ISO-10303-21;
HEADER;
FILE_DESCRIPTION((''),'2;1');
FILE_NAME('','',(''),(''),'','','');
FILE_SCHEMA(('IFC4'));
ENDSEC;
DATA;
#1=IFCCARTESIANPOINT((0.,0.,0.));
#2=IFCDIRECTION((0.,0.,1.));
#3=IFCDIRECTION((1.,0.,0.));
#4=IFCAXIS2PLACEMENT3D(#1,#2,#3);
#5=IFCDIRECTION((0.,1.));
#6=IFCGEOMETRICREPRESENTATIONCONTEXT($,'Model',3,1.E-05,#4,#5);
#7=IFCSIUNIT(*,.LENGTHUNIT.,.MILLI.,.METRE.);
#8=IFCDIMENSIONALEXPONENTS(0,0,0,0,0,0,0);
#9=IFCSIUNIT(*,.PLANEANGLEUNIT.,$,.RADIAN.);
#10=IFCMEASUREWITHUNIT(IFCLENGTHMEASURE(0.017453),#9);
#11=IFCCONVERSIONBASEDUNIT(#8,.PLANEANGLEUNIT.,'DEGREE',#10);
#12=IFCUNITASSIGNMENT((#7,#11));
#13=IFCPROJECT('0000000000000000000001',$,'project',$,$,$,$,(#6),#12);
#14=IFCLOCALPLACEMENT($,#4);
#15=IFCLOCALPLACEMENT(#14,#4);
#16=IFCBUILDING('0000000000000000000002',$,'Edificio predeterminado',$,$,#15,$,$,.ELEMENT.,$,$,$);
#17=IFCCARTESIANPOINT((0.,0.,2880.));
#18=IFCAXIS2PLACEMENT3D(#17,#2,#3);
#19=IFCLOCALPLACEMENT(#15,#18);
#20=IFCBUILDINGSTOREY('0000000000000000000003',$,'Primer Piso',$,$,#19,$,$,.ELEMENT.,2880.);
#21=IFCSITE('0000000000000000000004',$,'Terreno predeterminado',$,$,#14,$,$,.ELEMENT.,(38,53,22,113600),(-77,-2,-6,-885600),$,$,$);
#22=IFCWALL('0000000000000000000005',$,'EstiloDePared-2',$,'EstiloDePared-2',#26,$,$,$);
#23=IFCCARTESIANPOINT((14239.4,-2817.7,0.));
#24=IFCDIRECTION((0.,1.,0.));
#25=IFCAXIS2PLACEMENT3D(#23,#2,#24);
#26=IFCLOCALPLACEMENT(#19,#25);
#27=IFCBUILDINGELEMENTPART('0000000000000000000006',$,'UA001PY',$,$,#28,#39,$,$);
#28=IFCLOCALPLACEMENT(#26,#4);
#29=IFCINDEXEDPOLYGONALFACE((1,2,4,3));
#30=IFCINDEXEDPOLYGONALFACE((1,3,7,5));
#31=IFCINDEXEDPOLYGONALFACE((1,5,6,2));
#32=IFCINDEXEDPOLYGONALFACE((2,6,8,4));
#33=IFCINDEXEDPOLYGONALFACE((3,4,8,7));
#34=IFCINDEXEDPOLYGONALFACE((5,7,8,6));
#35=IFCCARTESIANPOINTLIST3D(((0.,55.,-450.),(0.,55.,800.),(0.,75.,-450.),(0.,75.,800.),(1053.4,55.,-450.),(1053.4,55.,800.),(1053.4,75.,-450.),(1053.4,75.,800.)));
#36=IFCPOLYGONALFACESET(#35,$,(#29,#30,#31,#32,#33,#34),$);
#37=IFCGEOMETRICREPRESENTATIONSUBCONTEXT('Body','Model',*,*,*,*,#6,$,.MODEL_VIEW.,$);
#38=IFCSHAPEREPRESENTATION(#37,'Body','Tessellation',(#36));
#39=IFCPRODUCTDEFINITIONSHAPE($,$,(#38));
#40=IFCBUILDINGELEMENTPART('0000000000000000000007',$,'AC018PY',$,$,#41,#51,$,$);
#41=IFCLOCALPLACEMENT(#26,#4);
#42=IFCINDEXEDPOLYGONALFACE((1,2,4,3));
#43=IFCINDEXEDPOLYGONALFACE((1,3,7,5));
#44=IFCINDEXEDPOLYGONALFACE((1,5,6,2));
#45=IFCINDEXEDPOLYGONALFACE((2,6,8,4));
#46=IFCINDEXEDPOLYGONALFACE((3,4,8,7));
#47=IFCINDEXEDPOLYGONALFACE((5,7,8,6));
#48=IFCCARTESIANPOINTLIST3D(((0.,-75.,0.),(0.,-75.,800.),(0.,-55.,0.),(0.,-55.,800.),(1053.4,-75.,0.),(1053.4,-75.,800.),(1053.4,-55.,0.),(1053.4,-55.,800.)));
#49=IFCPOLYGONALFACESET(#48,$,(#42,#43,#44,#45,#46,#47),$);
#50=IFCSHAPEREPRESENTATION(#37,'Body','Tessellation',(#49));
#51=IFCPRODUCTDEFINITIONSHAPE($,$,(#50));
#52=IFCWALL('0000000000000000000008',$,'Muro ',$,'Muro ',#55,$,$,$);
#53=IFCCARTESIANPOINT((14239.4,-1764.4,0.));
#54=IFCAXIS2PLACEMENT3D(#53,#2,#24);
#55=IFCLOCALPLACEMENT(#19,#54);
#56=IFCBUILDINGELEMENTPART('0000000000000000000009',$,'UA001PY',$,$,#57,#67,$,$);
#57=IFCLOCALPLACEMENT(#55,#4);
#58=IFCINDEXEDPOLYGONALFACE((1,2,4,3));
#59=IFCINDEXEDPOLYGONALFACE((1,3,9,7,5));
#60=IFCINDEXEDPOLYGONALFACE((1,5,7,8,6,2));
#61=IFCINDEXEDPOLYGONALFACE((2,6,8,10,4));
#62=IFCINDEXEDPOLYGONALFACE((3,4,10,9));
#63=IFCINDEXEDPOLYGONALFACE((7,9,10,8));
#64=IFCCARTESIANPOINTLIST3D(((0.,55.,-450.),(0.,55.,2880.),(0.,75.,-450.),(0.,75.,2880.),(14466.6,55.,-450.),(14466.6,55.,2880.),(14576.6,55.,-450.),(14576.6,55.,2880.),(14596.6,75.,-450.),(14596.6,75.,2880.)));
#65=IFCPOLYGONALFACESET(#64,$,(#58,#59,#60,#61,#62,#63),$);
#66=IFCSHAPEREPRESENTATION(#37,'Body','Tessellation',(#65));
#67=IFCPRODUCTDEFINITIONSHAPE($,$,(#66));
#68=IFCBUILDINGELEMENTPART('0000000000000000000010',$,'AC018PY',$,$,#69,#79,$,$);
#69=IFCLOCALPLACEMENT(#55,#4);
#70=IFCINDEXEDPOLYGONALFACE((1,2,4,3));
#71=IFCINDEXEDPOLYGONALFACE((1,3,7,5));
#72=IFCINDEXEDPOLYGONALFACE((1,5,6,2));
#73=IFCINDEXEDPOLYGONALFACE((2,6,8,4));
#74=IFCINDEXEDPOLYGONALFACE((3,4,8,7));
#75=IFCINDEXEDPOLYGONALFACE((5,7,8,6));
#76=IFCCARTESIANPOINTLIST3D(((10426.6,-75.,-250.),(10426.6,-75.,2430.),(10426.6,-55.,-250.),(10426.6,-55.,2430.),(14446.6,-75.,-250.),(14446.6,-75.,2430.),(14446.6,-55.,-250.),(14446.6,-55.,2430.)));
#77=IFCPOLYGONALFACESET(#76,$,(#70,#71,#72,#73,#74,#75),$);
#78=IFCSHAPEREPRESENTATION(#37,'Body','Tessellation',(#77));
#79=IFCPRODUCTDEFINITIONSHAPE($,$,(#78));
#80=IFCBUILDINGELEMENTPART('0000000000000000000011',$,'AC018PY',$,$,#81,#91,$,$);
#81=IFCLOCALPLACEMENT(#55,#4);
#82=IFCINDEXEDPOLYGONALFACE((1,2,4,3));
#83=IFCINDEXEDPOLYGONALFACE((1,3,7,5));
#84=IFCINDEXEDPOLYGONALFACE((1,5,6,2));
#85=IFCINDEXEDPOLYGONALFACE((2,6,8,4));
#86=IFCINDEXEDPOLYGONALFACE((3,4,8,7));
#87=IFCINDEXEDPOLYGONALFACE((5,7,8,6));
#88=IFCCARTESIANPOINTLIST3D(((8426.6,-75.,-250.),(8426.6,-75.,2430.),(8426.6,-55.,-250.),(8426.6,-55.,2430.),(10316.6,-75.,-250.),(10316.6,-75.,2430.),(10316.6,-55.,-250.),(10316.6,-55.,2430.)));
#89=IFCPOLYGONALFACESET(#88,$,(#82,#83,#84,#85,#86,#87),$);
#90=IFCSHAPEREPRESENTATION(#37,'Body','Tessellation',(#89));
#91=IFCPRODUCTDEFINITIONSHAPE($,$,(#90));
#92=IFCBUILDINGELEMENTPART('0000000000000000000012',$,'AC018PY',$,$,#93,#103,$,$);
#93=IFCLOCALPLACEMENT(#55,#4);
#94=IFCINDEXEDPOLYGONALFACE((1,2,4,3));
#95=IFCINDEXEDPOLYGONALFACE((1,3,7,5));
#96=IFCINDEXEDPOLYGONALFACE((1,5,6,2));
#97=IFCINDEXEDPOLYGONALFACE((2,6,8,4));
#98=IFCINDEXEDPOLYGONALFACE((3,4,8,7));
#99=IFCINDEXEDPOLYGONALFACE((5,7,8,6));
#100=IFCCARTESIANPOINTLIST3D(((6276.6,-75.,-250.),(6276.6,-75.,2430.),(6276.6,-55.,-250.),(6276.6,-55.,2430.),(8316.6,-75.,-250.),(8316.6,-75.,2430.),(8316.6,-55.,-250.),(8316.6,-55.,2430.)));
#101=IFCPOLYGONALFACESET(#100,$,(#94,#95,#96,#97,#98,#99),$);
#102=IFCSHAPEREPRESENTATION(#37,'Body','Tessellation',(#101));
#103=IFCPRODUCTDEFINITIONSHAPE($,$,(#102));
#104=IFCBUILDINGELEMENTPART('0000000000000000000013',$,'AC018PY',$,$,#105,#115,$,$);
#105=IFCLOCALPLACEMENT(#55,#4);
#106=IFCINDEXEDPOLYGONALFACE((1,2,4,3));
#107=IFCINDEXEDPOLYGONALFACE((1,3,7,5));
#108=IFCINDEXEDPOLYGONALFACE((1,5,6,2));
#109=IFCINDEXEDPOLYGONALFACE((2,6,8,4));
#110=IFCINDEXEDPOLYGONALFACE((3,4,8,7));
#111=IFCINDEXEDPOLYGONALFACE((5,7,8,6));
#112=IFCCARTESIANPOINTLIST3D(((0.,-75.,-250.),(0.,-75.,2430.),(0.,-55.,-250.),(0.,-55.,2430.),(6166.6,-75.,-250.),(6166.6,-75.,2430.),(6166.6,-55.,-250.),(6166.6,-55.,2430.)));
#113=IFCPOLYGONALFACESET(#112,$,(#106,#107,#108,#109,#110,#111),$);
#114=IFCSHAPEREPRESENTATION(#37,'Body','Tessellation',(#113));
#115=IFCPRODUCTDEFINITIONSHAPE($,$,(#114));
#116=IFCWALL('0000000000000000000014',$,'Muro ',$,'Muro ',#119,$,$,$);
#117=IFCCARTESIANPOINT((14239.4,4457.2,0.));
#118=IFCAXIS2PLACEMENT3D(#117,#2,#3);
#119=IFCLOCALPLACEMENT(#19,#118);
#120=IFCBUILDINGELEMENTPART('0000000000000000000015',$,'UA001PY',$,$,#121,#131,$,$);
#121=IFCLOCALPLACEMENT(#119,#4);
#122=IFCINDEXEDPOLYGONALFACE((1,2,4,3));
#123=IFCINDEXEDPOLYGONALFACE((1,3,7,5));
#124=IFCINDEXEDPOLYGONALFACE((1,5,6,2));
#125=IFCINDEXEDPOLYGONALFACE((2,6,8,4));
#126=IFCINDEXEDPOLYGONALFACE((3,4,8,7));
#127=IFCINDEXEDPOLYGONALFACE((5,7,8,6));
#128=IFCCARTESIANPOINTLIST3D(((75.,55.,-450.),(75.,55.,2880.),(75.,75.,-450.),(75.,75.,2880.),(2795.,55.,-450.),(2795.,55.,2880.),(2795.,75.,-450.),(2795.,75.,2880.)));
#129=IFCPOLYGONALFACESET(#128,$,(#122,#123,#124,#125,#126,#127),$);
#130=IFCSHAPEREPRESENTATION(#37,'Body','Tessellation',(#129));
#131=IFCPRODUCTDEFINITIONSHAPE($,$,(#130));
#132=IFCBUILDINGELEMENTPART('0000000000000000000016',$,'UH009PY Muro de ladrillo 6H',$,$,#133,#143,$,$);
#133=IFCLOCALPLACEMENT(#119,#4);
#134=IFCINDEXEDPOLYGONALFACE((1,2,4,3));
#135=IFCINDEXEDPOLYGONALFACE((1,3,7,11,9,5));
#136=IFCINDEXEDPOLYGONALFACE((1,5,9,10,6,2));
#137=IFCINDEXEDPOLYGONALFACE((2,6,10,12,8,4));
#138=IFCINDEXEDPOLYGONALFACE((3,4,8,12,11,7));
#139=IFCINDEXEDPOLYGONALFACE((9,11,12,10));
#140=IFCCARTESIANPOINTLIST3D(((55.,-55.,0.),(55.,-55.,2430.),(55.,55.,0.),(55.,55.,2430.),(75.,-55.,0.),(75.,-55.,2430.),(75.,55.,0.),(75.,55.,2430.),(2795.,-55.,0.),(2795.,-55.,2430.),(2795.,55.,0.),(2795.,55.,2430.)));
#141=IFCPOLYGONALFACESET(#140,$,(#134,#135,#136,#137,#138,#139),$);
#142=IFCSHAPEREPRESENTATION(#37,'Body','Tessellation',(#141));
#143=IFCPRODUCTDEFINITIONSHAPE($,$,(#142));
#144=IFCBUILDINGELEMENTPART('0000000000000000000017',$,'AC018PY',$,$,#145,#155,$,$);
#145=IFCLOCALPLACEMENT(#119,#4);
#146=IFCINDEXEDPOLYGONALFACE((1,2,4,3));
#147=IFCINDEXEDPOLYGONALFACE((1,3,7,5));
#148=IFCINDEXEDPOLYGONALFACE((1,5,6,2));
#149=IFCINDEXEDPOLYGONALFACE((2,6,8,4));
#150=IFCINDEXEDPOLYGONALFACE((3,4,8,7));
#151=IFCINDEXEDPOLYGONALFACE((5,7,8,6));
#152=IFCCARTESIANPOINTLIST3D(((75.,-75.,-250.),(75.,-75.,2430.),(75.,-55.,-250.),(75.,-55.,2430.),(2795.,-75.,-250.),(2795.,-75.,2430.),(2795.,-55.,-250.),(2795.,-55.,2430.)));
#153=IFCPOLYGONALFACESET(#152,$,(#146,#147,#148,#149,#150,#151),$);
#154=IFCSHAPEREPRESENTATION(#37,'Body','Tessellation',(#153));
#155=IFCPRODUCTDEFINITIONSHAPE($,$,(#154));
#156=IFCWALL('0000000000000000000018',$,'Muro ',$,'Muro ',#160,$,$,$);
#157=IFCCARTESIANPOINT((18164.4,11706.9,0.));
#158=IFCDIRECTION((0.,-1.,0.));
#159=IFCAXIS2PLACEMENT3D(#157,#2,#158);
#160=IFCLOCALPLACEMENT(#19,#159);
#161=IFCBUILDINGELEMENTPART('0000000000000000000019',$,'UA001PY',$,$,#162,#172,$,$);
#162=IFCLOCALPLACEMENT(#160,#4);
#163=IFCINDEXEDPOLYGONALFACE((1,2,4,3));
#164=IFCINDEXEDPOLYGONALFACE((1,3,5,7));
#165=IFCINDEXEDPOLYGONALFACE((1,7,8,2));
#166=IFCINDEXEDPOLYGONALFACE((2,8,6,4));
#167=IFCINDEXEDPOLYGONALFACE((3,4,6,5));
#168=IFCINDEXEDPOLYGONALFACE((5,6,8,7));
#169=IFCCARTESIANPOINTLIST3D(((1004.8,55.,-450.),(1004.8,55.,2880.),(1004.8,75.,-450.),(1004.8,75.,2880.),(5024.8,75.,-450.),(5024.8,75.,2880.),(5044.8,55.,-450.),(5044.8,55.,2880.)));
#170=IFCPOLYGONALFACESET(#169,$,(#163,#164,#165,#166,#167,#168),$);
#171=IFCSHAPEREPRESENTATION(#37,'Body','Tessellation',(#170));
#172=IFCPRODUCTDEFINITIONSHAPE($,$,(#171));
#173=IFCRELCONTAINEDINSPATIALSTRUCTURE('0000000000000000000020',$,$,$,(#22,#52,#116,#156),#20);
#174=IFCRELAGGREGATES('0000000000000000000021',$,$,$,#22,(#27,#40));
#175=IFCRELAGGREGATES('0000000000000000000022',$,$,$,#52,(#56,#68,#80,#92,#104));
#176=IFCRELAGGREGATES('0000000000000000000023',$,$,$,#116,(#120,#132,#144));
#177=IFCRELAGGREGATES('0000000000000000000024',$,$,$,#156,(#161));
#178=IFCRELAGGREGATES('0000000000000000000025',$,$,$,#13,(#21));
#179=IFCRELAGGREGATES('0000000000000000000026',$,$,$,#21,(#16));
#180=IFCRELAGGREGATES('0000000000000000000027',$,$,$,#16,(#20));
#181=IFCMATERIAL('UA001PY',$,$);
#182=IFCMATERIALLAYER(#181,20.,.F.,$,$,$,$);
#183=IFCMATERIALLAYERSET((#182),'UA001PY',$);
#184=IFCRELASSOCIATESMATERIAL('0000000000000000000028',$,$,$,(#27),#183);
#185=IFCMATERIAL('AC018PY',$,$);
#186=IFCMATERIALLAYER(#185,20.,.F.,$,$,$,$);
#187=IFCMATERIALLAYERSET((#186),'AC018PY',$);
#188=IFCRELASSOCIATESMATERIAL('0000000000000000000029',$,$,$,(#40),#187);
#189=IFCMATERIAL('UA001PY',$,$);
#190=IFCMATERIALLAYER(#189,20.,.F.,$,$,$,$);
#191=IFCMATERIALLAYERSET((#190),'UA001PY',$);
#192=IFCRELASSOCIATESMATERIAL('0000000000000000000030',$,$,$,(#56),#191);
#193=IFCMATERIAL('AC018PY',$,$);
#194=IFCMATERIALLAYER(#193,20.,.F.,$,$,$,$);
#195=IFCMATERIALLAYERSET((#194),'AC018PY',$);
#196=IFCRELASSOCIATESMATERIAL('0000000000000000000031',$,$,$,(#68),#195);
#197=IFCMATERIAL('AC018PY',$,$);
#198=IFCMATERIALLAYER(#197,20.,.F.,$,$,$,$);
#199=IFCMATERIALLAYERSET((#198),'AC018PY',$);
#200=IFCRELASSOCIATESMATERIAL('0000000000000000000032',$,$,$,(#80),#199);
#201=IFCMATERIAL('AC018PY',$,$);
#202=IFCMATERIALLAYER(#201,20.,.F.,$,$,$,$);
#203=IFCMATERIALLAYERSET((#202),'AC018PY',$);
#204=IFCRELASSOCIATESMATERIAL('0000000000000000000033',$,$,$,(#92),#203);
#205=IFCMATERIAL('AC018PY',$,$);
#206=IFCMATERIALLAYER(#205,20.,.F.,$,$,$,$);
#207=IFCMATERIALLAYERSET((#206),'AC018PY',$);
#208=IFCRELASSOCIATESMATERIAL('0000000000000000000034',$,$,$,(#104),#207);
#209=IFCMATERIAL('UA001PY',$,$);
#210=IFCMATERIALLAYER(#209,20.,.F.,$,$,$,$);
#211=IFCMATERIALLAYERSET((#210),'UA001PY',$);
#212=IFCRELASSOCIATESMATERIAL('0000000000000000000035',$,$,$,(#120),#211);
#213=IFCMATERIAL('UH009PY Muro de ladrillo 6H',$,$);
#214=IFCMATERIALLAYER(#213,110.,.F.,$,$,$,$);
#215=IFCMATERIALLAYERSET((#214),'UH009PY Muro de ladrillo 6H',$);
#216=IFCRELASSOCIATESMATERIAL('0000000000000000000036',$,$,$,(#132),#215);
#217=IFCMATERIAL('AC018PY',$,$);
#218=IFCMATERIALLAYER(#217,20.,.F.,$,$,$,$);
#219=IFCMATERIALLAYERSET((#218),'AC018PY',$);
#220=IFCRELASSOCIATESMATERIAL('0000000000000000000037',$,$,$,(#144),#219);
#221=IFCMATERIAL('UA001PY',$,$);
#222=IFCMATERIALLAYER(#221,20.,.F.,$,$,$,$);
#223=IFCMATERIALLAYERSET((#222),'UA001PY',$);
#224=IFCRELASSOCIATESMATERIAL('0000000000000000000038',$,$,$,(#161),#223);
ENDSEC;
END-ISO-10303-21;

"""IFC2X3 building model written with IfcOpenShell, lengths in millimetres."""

from ifc_helpers import new_model, entity, si_unit, converted_unit, direction, frame, origin_with_axes, place, context, subcontext, project, spatial, polyline, outline, extrude, material, layer, layer_set, layer_usage, element, aggregate, save


model = new_model("IFC2X3")

# Units and contexts
model_context = context("Model", 3, precision=1e-05, world=origin_with_axes(), true_north=direction((0.0, 1.0)))
body_context = subcontext(model_context, "Body", "Model", "MODEL_VIEW")
ifc_project = project(units=[si_unit("LENGTHUNIT", "METRE", prefix="MILLI"), converted_unit("PLANEANGLEUNIT", "DEGREE", entity("IfcLengthMeasure", 0.017453), si_unit("PLANEANGLEUNIT", "RADIAN"), dimensions=[0, 0, 0, 0, 0, 0, 0])], contexts=[model_context])

# Site, building, storey
site_placement = place(None, origin_with_axes())
site = spatial("IfcSite", under=ifc_project, at=site_placement, Name="Terreno predeterminado", CompositionType="ELEMENT", RefLatitude=(38, 53, 22, 113600), RefLongitude=(-77, -2, -6, -885600))
building_placement = place(site_placement, origin_with_axes())
building = spatial("IfcBuilding", under=site, at=building_placement, Name="Edificio predeterminado", CompositionType="ELEMENT")
storey_placement = place(building_placement, frame((0.0, 0.0, 2880.0), z_axis=(0.0, 0.0, 1.0), x_axis=(1.0, 0.0, 0.0)))
storey = spatial("IfcBuildingStorey", under=building, at=storey_placement, Name="Primer Piso", CompositionType="ELEMENT", Elevation=2880.0)

# Walls, building element parts
wall_1_placement = place(storey_placement, frame((14239.4, -2817.7, 0.0), z_axis=(0.0, 0.0, 1.0), x_axis=(0.0, 1.0, 0.0)))
wall_1 = element("IfcWall", 1, at=wall_1_placement, inside=storey, Name="EstiloDePared-2", ObjectType="EstiloDePared-2")
ifc_material_1 = material(Name="UA001PY")
ifc_layer_1 = layer(ifc_material_1, 20.0, ventilated=False)
ifc_layer_set_1 = layer_set([ifc_layer_1], Name="UA001PY")
ifc_layer_usage_1 = layer_usage(ifc_layer_set_1, "AXIS2", "NEGATIVE", -75.0)
building_element_part_1_placement = place(wall_1_placement, origin_with_axes())
building_element_part_1 = element("IfcBuildingElementPart", 2, at=building_element_part_1_placement, material=ifc_layer_usage_1, Name="UA001PY", context=body_context, shape_type="SweptSolid", body=[
    extrude(outline(polyline([(1053.4, 75.0), (1053.4, 55.0), (0.0, 55.0), (0.0, 75.0), (1053.4, 75.0)])), frame((0.0, 0.0, -450.0), z_axis=(0.0, 0.0, 1.0), x_axis=(1.0, 0.0, 0.0)), (0.0, 0.0, 1.0), 1250.0),
])
ifc_material_2 = material(Name="AC018PY")
ifc_layer_2 = layer(ifc_material_2, 20.0, ventilated=False)
ifc_layer_set_2 = layer_set([ifc_layer_2], Name="AC018PY")
ifc_layer_usage_2 = layer_usage(ifc_layer_set_2, "AXIS2", "NEGATIVE", 55.0)
building_element_part_2_placement = place(wall_1_placement, origin_with_axes())
building_element_part_2 = element("IfcBuildingElementPart", 3, at=building_element_part_2_placement, material=ifc_layer_usage_2, Name="AC018PY", context=body_context, shape_type="SweptSolid", body=[
    extrude(outline(polyline([(1053.4, -55.0), (1053.4, -75.0), (0.0, -75.0), (0.0, -55.0), (1053.4, -55.0)])), origin_with_axes(), (0.0, 0.0, 1.0), 800.0),
])
aggregate(wall_1, [building_element_part_1, building_element_part_2])
wall_2_placement = place(storey_placement, frame((14239.4, -1764.4, 0.0), z_axis=(0.0, 0.0, 1.0), x_axis=(0.0, 1.0, 0.0)))
wall_2 = element("IfcWall", 4, at=wall_2_placement, inside=storey, Name="Muro ", ObjectType="Muro ")
ifc_material_3 = material(Name="UA001PY")
ifc_layer_3 = layer(ifc_material_3, 20.0, ventilated=False)
ifc_layer_set_3 = layer_set([ifc_layer_3], Name="UA001PY")
ifc_layer_usage_3 = layer_usage(ifc_layer_set_3, "AXIS2", "NEGATIVE", -75.0)
building_element_part_3_placement = place(wall_2_placement, origin_with_axes())
building_element_part_3 = element("IfcBuildingElementPart", 5, at=building_element_part_3_placement, material=ifc_layer_usage_3, Name="UA001PY", context=body_context, shape_type="SweptSolid", body=[
    extrude(outline(polyline([(14596.6, 75.0), (14576.6, 55.0), (14466.6, 55.0), (0.0, 55.0), (0.0, 75.0), (14596.6, 75.0)])), frame((0.0, 0.0, -450.0), z_axis=(0.0, 0.0, 1.0), x_axis=(1.0, 0.0, 0.0)), (0.0, 0.0, 1.0), 3330.0),
])
ifc_material_4 = material(Name="AC018PY")
ifc_layer_4 = layer(ifc_material_4, 20.0, ventilated=False)
ifc_layer_set_4 = layer_set([ifc_layer_4], Name="AC018PY")
ifc_layer_usage_4 = layer_usage(ifc_layer_set_4, "AXIS2", "NEGATIVE", 55.0)
building_element_part_4_placement = place(wall_2_placement, origin_with_axes())
building_element_part_4 = element("IfcBuildingElementPart", 6, at=building_element_part_4_placement, material=ifc_layer_usage_4, Name="AC018PY", context=body_context, shape_type="SweptSolid", body=[
    extrude(outline(polyline([(14446.6, -55.0), (14446.6, -75.0), (10426.6, -75.0), (10426.6, -55.0), (14446.6, -55.0)])), frame((0.0, 0.0, -250.0), z_axis=(0.0, 0.0, 1.0), x_axis=(1.0, 0.0, 0.0)), (0.0, 0.0, 1.0), 2680.0),
])
ifc_material_5 = material(Name="AC018PY")
ifc_layer_5 = layer(ifc_material_5, 20.0, ventilated=False)
ifc_layer_set_5 = layer_set([ifc_layer_5], Name="AC018PY")
ifc_layer_usage_5 = layer_usage(ifc_layer_set_5, "AXIS2", "NEGATIVE", 55.0)
building_element_part_5_placement = place(wall_2_placement, origin_with_axes())
building_element_part_5 = element("IfcBuildingElementPart", 7, at=building_element_part_5_placement, material=ifc_layer_usage_5, Name="AC018PY", context=body_context, shape_type="SweptSolid", body=[
    extrude(outline(polyline([(10316.6, -55.0), (10316.6, -75.0), (8426.6, -75.0), (8426.6, -55.0), (10316.6, -55.0)])), frame((0.0, 0.0, -250.0), z_axis=(0.0, 0.0, 1.0), x_axis=(1.0, 0.0, 0.0)), (0.0, 0.0, 1.0), 2680.0),
])
ifc_material_6 = material(Name="AC018PY")
ifc_layer_6 = layer(ifc_material_6, 20.0, ventilated=False)
ifc_layer_set_6 = layer_set([ifc_layer_6], Name="AC018PY")
ifc_layer_usage_6 = layer_usage(ifc_layer_set_6, "AXIS2", "NEGATIVE", 55.0)
building_element_part_6_placement = place(wall_2_placement, origin_with_axes())
building_element_part_6 = element("IfcBuildingElementPart", 8, at=building_element_part_6_placement, material=ifc_layer_usage_6, Name="AC018PY", context=body_context, shape_type="SweptSolid", body=[
    extrude(outline(polyline([(8316.6, -55.0), (8316.6, -75.0), (6276.6, -75.0), (6276.6, -55.0), (8316.6, -55.0)])), frame((0.0, 0.0, -250.0), z_axis=(0.0, 0.0, 1.0), x_axis=(1.0, 0.0, 0.0)), (0.0, 0.0, 1.0), 2680.0),
])
ifc_material_7 = material(Name="AC018PY")
ifc_layer_7 = layer(ifc_material_7, 20.0, ventilated=False)
ifc_layer_set_7 = layer_set([ifc_layer_7], Name="AC018PY")
ifc_layer_usage_7 = layer_usage(ifc_layer_set_7, "AXIS2", "NEGATIVE", 55.0)
building_element_part_7_placement = place(wall_2_placement, origin_with_axes())
building_element_part_7 = element("IfcBuildingElementPart", 9, at=building_element_part_7_placement, material=ifc_layer_usage_7, Name="AC018PY", context=body_context, shape_type="SweptSolid", body=[
    extrude(outline(polyline([(6166.6, -55.0), (6166.6, -75.0), (0.0, -75.0), (0.0, -55.0), (6166.6, -55.0)])), frame((0.0, 0.0, -250.0), z_axis=(0.0, 0.0, 1.0), x_axis=(1.0, 0.0, 0.0)), (0.0, 0.0, 1.0), 2680.0),
])
aggregate(wall_2, [building_element_part_3, building_element_part_4, building_element_part_5, building_element_part_6, building_element_part_7])
wall_3_placement = place(storey_placement, frame((14239.4, 4457.2, 0.0), z_axis=(0.0, 0.0, 1.0), x_axis=(1.0, 0.0, 0.0)))
wall_3 = element("IfcWall", 10, at=wall_3_placement, inside=storey, Name="Muro ", ObjectType="Muro ")
ifc_material_8 = material(Name="UA001PY")
ifc_layer_8 = layer(ifc_material_8, 20.0, ventilated=False)
ifc_layer_set_8 = layer_set([ifc_layer_8], Name="UA001PY")
ifc_layer_usage_8 = layer_usage(ifc_layer_set_8, "AXIS2", "NEGATIVE", -75.0)
building_element_part_8_placement = place(wall_3_placement, origin_with_axes())
building_element_part_8 = element("IfcBuildingElementPart", 11, at=building_element_part_8_placement, material=ifc_layer_usage_8, Name="UA001PY", context=body_context, shape_type="SweptSolid", body=[
    extrude(outline(polyline([(2795.0, 75.0), (2795.0, 55.0), (75.0, 55.0), (75.0, 75.0), (2795.0, 75.0)])), frame((0.0, 0.0, -450.0), z_axis=(0.0, 0.0, 1.0), x_axis=(1.0, 0.0, 0.0)), (0.0, 0.0, 1.0), 3330.0),
])
ifc_material_9 = material(Name="UH009PY Muro de ladrillo 6H")
ifc_layer_9 = layer(ifc_material_9, 110.0, ventilated=False)
ifc_layer_set_9 = layer_set([ifc_layer_9], Name="UH009PY Muro de ladrillo 6H")
ifc_layer_usage_9 = layer_usage(ifc_layer_set_9, "AXIS2", "NEGATIVE", -55.0)
building_element_part_9_placement = place(wall_3_placement, origin_with_axes())
building_element_part_9 = element("IfcBuildingElementPart", 12, at=building_element_part_9_placement, material=ifc_layer_usage_9, Name="UH009PY Muro de ladrillo 6H", context=body_context, shape_type="SweptSolid", body=[
    extrude(outline(polyline([(2795.0, 55.0), (2795.0, -55.0), (75.0, -55.0), (55.0, -55.0), (55.0, 55.0), (75.0, 55.0), (2795.0, 55.0)])), origin_with_axes(), (0.0, 0.0, 1.0), 2430.0),
])
ifc_material_10 = material(Name="AC018PY")
ifc_layer_10 = layer(ifc_material_10, 20.0, ventilated=False)
ifc_layer_set_10 = layer_set([ifc_layer_10], Name="AC018PY")
ifc_layer_usage_10 = layer_usage(ifc_layer_set_10, "AXIS2", "NEGATIVE", 55.0)
building_element_part_10_placement = place(wall_3_placement, origin_with_axes())
building_element_part_10 = element("IfcBuildingElementPart", 13, at=building_element_part_10_placement, material=ifc_layer_usage_10, Name="AC018PY", context=body_context, shape_type="SweptSolid", body=[
    extrude(outline(polyline([(75.0, -55.0), (2795.0, -55.0), (2795.0, -75.0), (75.0, -75.0), (75.0, -55.0)])), frame((0.0, 0.0, -250.0), z_axis=(0.0, 0.0, 1.0), x_axis=(1.0, 0.0, 0.0)), (0.0, 0.0, 1.0), 2680.0),
])
aggregate(wall_3, [building_element_part_8, building_element_part_9, building_element_part_10])
wall_4_placement = place(storey_placement, frame((18164.4, 11706.9, 0.0), z_axis=(0.0, 0.0, 1.0), x_axis=(0.0, -1.0, 0.0)))
wall_4 = element("IfcWall", 14, at=wall_4_placement, inside=storey, Name="Muro ", ObjectType="Muro ")
ifc_material_11 = material(Name="UA001PY")
ifc_layer_11 = layer(ifc_material_11, 20.0, ventilated=False)
ifc_layer_set_11 = layer_set([ifc_layer_11], Name="UA001PY")
ifc_layer_usage_11 = layer_usage(ifc_layer_set_11, "AXIS2", "NEGATIVE", -75.0)
building_element_part_11_placement = place(wall_4_placement, origin_with_axes())
building_element_part_11 = element("IfcBuildingElementPart", 15, at=building_element_part_11_placement, material=ifc_layer_usage_11, Name="UA001PY", context=body_context, shape_type="SweptSolid", body=[
    extrude(outline(polyline([(5024.8, 75.0), (5044.8, 55.0), (1004.8, 55.0), (1004.8, 75.0), (5024.8, 75.0)])), frame((0.0, 0.0, -450.0), z_axis=(0.0, 0.0, 1.0), x_axis=(1.0, 0.0, 0.0)), (0.0, 0.0, 1.0), 3330.0),
])
aggregate(wall_4, [building_element_part_11])

save(model, "model.ifc")
